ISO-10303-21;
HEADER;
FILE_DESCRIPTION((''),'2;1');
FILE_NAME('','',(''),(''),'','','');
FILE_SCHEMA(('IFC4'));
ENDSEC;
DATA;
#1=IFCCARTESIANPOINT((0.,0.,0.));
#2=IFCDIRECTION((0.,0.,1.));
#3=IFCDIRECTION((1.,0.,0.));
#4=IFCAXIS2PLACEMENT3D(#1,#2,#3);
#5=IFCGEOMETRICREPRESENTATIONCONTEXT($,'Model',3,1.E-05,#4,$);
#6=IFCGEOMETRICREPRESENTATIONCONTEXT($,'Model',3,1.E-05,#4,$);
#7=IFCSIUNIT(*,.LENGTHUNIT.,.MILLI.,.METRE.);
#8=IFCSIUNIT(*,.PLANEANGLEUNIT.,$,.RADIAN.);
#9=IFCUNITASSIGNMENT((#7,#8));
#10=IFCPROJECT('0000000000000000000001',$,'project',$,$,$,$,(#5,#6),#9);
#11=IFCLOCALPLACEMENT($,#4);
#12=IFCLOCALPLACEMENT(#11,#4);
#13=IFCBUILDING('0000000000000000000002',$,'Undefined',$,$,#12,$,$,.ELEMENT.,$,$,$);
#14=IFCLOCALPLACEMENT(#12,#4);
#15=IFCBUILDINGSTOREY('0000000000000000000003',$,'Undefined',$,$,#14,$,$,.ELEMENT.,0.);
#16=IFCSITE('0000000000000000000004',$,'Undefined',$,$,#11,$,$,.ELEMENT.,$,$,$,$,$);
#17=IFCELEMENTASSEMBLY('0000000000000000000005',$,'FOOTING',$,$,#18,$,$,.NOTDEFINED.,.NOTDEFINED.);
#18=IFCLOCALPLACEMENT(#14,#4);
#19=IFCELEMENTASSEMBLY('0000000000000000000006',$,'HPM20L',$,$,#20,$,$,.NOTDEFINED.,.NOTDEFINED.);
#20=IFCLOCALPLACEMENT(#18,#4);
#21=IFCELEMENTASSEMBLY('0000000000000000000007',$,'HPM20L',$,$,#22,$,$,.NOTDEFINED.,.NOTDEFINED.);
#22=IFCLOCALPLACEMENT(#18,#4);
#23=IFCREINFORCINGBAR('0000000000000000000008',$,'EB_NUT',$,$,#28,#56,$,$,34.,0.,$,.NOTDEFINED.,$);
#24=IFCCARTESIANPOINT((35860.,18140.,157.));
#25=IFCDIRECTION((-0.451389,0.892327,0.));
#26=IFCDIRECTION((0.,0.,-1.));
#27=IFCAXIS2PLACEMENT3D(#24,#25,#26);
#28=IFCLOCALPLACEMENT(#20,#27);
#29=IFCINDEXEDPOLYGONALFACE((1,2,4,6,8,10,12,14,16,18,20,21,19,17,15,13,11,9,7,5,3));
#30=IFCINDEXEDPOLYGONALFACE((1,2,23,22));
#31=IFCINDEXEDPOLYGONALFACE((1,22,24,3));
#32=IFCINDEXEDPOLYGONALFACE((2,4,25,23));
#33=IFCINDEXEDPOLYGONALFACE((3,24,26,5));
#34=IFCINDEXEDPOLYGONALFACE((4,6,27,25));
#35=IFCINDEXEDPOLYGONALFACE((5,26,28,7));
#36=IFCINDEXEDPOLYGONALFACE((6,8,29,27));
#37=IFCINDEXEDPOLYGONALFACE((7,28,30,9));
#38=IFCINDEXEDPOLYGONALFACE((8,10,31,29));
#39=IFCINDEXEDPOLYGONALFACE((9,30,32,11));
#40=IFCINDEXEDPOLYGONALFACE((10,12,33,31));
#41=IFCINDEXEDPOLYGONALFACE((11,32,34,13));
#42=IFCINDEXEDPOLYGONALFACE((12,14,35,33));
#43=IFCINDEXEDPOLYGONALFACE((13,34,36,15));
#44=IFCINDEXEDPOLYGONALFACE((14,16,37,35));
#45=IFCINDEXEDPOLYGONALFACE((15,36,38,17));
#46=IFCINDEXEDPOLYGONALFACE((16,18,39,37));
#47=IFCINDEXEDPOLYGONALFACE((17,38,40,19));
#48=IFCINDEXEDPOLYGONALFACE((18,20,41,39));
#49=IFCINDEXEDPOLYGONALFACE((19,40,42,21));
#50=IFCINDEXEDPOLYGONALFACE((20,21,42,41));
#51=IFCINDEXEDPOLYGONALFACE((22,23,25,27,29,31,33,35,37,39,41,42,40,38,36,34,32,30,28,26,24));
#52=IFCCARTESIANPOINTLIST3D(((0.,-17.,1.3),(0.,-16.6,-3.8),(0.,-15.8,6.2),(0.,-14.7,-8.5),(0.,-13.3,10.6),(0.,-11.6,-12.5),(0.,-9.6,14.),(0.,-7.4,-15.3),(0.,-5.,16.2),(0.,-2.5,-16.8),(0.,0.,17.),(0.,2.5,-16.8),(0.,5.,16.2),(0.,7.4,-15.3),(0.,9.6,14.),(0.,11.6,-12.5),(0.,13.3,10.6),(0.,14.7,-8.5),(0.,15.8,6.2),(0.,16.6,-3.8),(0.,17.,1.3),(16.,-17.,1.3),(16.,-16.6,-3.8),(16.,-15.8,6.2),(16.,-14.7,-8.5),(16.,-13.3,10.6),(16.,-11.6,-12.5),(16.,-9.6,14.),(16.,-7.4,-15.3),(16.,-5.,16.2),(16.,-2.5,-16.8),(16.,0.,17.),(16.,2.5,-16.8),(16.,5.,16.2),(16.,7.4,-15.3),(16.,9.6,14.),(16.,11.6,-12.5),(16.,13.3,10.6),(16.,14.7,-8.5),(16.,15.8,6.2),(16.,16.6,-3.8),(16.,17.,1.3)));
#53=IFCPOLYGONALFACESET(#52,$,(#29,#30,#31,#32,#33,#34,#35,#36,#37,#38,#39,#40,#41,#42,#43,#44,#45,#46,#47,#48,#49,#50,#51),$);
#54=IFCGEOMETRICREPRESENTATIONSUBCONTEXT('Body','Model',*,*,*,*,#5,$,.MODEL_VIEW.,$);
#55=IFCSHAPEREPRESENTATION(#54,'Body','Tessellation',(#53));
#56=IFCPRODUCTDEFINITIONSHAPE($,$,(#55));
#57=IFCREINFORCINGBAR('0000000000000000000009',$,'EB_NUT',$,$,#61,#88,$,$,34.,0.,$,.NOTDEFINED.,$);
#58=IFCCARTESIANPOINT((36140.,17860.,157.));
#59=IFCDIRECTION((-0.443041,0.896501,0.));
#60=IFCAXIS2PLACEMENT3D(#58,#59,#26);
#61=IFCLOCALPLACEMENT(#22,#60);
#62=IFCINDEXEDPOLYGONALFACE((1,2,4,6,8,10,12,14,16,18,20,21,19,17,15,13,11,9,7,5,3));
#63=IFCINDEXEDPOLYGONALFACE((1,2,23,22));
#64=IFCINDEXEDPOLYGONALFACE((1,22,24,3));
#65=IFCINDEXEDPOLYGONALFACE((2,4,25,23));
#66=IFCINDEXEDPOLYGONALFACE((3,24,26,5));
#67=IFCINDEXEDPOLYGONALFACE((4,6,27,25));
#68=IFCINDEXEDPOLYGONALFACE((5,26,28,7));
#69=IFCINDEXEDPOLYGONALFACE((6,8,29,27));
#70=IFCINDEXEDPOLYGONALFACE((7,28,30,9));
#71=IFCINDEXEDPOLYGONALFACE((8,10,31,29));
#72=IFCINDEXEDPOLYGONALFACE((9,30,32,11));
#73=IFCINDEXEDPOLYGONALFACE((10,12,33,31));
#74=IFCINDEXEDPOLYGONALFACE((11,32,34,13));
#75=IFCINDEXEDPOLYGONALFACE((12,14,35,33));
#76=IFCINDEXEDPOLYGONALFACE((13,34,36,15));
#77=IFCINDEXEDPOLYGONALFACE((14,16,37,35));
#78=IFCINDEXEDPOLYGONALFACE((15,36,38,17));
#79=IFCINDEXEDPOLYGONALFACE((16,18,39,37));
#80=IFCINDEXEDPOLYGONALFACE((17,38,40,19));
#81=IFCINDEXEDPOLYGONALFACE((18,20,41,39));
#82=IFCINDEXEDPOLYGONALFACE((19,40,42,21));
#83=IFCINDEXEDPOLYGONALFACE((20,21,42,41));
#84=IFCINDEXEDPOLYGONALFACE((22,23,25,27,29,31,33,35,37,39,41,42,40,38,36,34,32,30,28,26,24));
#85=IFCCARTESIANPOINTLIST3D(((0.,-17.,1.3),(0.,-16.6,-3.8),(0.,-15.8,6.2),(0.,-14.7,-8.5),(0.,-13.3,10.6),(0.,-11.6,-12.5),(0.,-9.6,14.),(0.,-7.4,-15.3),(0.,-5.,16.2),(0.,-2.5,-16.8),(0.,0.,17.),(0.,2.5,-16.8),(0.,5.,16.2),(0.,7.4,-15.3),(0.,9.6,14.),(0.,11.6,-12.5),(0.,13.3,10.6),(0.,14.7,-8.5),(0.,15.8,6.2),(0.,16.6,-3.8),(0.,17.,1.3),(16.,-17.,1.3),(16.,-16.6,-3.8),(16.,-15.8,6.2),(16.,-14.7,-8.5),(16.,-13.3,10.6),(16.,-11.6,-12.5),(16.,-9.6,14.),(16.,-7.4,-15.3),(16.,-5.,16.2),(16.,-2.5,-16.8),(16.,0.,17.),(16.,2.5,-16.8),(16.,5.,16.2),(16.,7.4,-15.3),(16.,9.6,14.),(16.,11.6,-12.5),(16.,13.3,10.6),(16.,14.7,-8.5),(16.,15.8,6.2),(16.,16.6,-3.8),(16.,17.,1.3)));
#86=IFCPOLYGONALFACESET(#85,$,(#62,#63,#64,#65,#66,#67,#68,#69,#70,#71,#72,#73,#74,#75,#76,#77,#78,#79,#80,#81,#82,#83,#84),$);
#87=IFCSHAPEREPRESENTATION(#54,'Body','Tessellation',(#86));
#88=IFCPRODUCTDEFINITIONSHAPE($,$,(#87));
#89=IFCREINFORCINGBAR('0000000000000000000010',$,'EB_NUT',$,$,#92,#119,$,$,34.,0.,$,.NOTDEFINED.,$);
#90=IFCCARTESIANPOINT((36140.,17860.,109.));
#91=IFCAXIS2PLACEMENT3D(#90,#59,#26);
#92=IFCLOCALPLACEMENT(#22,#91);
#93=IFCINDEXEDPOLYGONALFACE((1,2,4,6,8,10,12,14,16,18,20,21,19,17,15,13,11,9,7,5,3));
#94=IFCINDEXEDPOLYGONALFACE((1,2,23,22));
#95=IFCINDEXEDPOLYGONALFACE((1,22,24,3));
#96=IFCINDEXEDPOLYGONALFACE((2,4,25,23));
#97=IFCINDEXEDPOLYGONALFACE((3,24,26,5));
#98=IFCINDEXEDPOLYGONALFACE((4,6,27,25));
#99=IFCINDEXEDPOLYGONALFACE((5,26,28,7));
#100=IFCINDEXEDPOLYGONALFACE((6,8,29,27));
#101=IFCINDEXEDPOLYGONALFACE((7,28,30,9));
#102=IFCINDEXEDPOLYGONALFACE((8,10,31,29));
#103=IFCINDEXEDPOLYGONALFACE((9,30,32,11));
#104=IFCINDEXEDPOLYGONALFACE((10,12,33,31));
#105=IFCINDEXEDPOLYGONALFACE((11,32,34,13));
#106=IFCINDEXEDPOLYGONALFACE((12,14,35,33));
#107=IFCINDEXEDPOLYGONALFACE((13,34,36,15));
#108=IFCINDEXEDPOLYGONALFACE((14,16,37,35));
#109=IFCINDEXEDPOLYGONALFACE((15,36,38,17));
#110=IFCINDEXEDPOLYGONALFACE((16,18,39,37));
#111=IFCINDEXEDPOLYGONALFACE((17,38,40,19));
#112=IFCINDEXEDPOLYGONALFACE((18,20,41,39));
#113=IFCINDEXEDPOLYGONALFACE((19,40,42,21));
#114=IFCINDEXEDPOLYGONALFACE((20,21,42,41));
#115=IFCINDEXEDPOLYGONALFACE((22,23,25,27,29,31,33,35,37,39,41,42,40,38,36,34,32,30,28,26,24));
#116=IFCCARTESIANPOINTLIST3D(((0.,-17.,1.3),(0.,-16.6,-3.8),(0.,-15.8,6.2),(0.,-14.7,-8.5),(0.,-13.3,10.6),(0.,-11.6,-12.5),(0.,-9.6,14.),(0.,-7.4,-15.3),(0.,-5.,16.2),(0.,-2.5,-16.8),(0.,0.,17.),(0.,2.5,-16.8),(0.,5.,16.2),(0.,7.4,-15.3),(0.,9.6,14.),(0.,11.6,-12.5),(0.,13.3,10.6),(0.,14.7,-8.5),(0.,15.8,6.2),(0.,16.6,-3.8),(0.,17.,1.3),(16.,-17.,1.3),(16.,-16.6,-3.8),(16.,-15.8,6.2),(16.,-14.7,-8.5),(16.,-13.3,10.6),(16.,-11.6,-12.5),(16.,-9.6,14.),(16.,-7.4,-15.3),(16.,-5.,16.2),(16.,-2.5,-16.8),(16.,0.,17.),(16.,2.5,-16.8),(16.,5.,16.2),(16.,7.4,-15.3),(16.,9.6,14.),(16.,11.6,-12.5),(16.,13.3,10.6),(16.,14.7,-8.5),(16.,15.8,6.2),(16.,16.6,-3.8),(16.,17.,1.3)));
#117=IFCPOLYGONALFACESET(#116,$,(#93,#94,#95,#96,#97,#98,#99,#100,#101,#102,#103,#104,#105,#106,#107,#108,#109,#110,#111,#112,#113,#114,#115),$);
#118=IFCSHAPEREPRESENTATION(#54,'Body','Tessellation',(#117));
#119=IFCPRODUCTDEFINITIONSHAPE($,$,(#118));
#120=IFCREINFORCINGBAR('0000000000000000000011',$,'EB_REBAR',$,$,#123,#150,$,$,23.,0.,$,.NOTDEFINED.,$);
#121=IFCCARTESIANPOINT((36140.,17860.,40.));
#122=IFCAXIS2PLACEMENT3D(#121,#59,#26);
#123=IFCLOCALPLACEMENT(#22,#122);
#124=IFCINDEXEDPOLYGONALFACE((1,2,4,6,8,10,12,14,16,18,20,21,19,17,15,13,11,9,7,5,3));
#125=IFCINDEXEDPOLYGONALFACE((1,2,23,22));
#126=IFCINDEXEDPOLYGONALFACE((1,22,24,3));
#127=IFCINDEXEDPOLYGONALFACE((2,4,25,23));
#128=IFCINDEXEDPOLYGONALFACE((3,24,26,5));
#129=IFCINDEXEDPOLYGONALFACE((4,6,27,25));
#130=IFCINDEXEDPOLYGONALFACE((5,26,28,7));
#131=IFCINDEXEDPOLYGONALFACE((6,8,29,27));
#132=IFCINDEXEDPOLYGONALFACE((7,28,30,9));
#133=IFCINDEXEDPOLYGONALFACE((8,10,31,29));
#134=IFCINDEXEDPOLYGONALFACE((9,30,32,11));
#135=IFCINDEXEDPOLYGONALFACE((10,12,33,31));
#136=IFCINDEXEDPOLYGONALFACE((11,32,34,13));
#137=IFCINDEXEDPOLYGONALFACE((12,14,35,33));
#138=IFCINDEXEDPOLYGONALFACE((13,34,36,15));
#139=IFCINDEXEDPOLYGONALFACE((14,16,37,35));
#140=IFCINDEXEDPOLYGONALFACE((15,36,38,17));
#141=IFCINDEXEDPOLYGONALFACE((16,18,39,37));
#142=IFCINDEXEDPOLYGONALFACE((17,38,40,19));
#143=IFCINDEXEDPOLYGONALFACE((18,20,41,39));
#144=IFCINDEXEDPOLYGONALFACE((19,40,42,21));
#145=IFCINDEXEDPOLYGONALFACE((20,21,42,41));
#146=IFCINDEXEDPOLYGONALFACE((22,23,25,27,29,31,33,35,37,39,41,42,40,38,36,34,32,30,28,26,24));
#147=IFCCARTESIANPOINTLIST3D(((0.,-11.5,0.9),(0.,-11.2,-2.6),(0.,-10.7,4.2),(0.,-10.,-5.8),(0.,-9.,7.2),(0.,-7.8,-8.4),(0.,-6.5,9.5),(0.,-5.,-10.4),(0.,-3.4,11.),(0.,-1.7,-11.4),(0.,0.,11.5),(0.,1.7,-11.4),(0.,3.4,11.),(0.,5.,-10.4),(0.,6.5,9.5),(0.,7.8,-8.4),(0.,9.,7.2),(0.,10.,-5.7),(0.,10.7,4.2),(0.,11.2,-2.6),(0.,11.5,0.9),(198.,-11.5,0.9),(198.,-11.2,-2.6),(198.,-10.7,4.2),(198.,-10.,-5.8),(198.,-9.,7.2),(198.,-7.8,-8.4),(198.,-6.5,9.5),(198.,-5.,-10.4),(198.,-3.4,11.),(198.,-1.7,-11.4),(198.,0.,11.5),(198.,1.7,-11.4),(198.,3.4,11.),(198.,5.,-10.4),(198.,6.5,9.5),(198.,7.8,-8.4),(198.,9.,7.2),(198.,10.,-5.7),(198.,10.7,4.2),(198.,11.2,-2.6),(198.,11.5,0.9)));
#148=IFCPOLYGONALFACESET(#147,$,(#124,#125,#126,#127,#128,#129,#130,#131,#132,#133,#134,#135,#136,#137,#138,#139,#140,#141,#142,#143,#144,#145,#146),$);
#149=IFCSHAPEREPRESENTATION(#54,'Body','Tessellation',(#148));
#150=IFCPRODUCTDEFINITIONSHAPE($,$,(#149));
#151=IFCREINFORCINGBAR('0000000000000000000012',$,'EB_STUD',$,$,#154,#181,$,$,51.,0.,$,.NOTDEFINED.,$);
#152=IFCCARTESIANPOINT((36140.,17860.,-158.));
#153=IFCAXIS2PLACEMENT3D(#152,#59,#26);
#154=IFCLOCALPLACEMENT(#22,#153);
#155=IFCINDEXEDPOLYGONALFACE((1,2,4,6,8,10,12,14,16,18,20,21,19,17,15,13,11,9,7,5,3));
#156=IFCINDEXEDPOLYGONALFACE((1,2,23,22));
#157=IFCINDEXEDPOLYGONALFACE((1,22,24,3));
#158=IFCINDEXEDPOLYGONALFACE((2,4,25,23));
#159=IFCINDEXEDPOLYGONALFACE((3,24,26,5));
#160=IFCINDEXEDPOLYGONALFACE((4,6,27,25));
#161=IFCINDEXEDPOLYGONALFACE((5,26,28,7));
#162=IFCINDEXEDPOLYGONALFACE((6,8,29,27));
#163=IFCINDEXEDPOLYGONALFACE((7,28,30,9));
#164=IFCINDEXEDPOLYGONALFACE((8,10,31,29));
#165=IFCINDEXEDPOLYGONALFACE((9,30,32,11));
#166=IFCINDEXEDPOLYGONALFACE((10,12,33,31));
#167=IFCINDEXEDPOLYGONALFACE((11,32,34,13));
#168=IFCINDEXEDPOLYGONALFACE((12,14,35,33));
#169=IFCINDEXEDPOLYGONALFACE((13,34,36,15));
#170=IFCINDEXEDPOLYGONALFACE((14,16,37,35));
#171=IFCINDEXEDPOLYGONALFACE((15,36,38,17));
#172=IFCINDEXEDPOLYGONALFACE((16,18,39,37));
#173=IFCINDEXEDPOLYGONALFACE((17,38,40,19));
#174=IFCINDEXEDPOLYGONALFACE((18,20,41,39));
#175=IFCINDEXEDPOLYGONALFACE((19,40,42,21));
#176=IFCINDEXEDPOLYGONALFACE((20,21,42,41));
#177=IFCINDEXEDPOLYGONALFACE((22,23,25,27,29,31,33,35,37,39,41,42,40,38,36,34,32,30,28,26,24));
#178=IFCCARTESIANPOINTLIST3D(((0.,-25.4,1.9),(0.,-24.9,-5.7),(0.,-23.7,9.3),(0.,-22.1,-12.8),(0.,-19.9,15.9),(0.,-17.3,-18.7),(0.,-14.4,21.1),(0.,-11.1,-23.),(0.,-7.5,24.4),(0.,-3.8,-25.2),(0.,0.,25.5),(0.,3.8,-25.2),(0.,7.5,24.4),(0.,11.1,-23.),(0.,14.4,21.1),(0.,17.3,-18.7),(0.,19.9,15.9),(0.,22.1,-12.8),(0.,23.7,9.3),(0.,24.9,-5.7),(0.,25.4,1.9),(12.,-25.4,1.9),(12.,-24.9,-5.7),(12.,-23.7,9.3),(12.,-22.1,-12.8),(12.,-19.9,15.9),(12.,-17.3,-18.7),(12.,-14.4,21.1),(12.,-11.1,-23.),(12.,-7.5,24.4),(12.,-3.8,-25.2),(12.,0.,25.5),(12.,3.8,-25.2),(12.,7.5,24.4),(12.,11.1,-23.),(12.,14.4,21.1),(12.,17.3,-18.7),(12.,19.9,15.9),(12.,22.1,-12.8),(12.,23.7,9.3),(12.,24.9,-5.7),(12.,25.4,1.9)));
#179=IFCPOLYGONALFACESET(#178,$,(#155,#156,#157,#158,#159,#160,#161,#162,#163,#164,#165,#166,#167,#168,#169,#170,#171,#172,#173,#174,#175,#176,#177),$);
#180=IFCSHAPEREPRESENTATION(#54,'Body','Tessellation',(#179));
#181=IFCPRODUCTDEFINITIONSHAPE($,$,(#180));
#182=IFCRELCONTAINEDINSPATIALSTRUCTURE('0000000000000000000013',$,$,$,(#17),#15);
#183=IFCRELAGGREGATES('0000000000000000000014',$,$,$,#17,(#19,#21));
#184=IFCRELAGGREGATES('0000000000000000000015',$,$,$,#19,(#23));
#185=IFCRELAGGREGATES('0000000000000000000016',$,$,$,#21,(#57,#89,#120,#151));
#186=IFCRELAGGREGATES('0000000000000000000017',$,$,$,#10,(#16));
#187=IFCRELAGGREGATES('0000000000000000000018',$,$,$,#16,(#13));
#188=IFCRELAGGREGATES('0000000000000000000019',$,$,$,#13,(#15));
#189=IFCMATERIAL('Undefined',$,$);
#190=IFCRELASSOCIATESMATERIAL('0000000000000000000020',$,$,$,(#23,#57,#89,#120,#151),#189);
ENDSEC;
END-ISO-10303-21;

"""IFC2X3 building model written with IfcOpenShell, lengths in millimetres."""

from ifc_helpers import new_model, entity, si_unit, frame, origin_with_axes, place, context, subcontext, project, spatial, source, transform, mapped, material, element, aggregate, save


model = new_model("IFC2X3")

# Units and contexts
model_context_1 = context("Model", 3, precision=1e-05, world=origin_with_axes())
model_context_2 = context("Model", 3, precision=1e-05, world=origin_with_axes())
body_context = subcontext(model_context_1, "Body", "Model", "MODEL_VIEW")
ifc_project = project(units=[si_unit("LENGTHUNIT", "METRE", prefix="MILLI"), si_unit("PLANEANGLEUNIT", "RADIAN")], contexts=[model_context_1, model_context_2])

# Site, building, storey
site_placement = place(None, origin_with_axes())
site = spatial("IfcSite", under=ifc_project, at=site_placement, Name="Undefined", CompositionType="ELEMENT")
building_placement = place(site_placement, origin_with_axes())
building = spatial("IfcBuilding", under=site, at=building_placement, Name="Undefined", CompositionType="ELEMENT")
storey_placement = place(building_placement, origin_with_axes())
storey = spatial("IfcBuildingStorey", under=building, at=storey_placement, Name="Undefined", CompositionType="ELEMENT", Elevation=0.0)

# Element assembly
assembly_1_placement = place(storey_placement, origin_with_axes())
assembly_1 = element("IfcElementAssembly", 1, at=assembly_1_placement, inside=storey, Name="FOOTING", AssemblyPlace="NOTDEFINED", PredefinedType="NOTDEFINED")

# Element assemblies
assembly_2_placement = place(assembly_1_placement, origin_with_axes())
assembly_2 = element("IfcElementAssembly", 2, at=assembly_2_placement, Name="HPM20L", AssemblyPlace="NOTDEFINED", PredefinedType="NOTDEFINED")
assembly_3_placement = place(assembly_1_placement, origin_with_axes())
assembly_3 = element("IfcElementAssembly", 3, at=assembly_3_placement, Name="HPM20L", AssemblyPlace="NOTDEFINED", PredefinedType="NOTDEFINED")

aggregate(assembly_1, [assembly_2, assembly_3])

# Shared definitions
ifc_material_1 = material(Name="Undefined")

# Reinforcing bars
shared_shape_1 = source(origin_with_axes(), body_context, "Body", "AdvancedSweptSolid", [
    entity("IfcSweptDiskSolid", entity("IfcTrimmedCurve", entity("IfcLine", entity("IfcCartesianPoint", [0.0, 0.0, 0.0]), entity("IfcVector", entity("IfcDirection", [1.0, 0.0, 0.0]), 1.0)), [entity("IfcParameterValue", 0.0)], [entity("IfcParameterValue", 16.0)], True, "PARAMETER"), 17.0, None, 0.0, 16.0),
])
reinforcing_bar_1_placement = place(assembly_2_placement, frame((35860.0, 18140.0, 157.0), z_axis=(-0.451389, 0.892327, 0.0), x_axis=(0.0, 0.0, -1.0)))
reinforcing_bar_1 = element("IfcReinforcingBar", 4, at=reinforcing_bar_1_placement, material=ifc_material_1, Name="EB_NUT", BarRole="NOTDEFINED", CrossSectionArea=0.0, NominalDiameter=34.0, context=body_context, shape_type="MappedRepresentation", body=[
    mapped(shared_shape_1, transform((0.0, 0.0, 0.0))),
])
aggregate(assembly_2, [reinforcing_bar_1])
shared_shape_2 = source(origin_with_axes(), body_context, "Body", "AdvancedSweptSolid", [
    entity("IfcSweptDiskSolid", entity("IfcTrimmedCurve", entity("IfcLine", entity("IfcCartesianPoint", [0.0, 0.0, 0.0]), entity("IfcVector", entity("IfcDirection", [1.0, 0.0, 0.0]), 1.0)), [entity("IfcParameterValue", 0.0)], [entity("IfcParameterValue", 16.0)], True, "PARAMETER"), 17.0, None, 0.0, 16.0),
])
reinforcing_bar_2_placement = place(assembly_3_placement, frame((36140.0, 17860.0, 157.0), z_axis=(-0.443041, 0.896501, 0.0), x_axis=(0.0, 0.0, -1.0)))
reinforcing_bar_2 = element("IfcReinforcingBar", 5, at=reinforcing_bar_2_placement, material=ifc_material_1, Name="EB_NUT", BarRole="NOTDEFINED", CrossSectionArea=0.0, NominalDiameter=34.0, context=body_context, shape_type="MappedRepresentation", body=[
    mapped(shared_shape_2, transform((0.0, 0.0, 0.0))),
])
shared_shape_3 = source(origin_with_axes(), body_context, "Body", "AdvancedSweptSolid", [
    entity("IfcSweptDiskSolid", entity("IfcTrimmedCurve", entity("IfcLine", entity("IfcCartesianPoint", [0.0, 0.0, 0.0]), entity("IfcVector", entity("IfcDirection", [1.0, 0.0, 0.0]), 1.0)), [entity("IfcParameterValue", 0.0)], [entity("IfcParameterValue", 16.0)], True, "PARAMETER"), 17.0, None, 0.0, 16.0),
])
reinforcing_bar_3_placement = place(assembly_3_placement, frame((36140.0, 17860.0, 109.0), z_axis=(-0.443041, 0.896501, 0.0), x_axis=(0.0, 0.0, -1.0)))
reinforcing_bar_3 = element("IfcReinforcingBar", 6, at=reinforcing_bar_3_placement, material=ifc_material_1, Name="EB_NUT", BarRole="NOTDEFINED", CrossSectionArea=0.0, NominalDiameter=34.0, context=body_context, shape_type="MappedRepresentation", body=[
    mapped(shared_shape_3, transform((0.0, 0.0, 0.0))),
])
shared_shape_4 = source(origin_with_axes(), body_context, "Body", "AdvancedSweptSolid", [
    entity("IfcSweptDiskSolid", entity("IfcTrimmedCurve", entity("IfcLine", entity("IfcCartesianPoint", [0.0, 0.0, 0.0]), entity("IfcVector", entity("IfcDirection", [1.0, 0.0, 0.0]), 1.0)), [entity("IfcParameterValue", 0.0)], [entity("IfcParameterValue", 198.0)], True, "PARAMETER"), 11.5, None, 0.0, 198.0),
])
reinforcing_bar_4_placement = place(assembly_3_placement, frame((36140.0, 17860.0, 40.0), z_axis=(-0.443041, 0.896501, 0.0), x_axis=(0.0, 0.0, -1.0)))
reinforcing_bar_4 = element("IfcReinforcingBar", 7, at=reinforcing_bar_4_placement, material=ifc_material_1, Name="EB_REBAR", BarRole="NOTDEFINED", CrossSectionArea=0.0, NominalDiameter=23.0, context=body_context, shape_type="MappedRepresentation", body=[
    mapped(shared_shape_4, transform((0.0, 0.0, 0.0))),
])
shared_shape_5 = source(origin_with_axes(), body_context, "Body", "AdvancedSweptSolid", [
    entity("IfcSweptDiskSolid", entity("IfcTrimmedCurve", entity("IfcLine", entity("IfcCartesianPoint", [0.0, 0.0, 0.0]), entity("IfcVector", entity("IfcDirection", [1.0, 0.0, 0.0]), 1.0)), [entity("IfcParameterValue", 0.0)], [entity("IfcParameterValue", 12.0)], True, "PARAMETER"), 25.5, None, 0.0, 12.0),
])
reinforcing_bar_5_placement = place(assembly_3_placement, frame((36140.0, 17860.0, -158.0), z_axis=(-0.443041, 0.896501, 0.0), x_axis=(0.0, 0.0, -1.0)))
reinforcing_bar_5 = element("IfcReinforcingBar", 8, at=reinforcing_bar_5_placement, material=ifc_material_1, Name="EB_STUD", BarRole="NOTDEFINED", CrossSectionArea=0.0, NominalDiameter=51.0, context=body_context, shape_type="MappedRepresentation", body=[
    mapped(shared_shape_5, transform((0.0, 0.0, 0.0))),
])
aggregate(assembly_3, [reinforcing_bar_2, reinforcing_bar_3, reinforcing_bar_4, reinforcing_bar_5])

save(model, "model.ifc")
